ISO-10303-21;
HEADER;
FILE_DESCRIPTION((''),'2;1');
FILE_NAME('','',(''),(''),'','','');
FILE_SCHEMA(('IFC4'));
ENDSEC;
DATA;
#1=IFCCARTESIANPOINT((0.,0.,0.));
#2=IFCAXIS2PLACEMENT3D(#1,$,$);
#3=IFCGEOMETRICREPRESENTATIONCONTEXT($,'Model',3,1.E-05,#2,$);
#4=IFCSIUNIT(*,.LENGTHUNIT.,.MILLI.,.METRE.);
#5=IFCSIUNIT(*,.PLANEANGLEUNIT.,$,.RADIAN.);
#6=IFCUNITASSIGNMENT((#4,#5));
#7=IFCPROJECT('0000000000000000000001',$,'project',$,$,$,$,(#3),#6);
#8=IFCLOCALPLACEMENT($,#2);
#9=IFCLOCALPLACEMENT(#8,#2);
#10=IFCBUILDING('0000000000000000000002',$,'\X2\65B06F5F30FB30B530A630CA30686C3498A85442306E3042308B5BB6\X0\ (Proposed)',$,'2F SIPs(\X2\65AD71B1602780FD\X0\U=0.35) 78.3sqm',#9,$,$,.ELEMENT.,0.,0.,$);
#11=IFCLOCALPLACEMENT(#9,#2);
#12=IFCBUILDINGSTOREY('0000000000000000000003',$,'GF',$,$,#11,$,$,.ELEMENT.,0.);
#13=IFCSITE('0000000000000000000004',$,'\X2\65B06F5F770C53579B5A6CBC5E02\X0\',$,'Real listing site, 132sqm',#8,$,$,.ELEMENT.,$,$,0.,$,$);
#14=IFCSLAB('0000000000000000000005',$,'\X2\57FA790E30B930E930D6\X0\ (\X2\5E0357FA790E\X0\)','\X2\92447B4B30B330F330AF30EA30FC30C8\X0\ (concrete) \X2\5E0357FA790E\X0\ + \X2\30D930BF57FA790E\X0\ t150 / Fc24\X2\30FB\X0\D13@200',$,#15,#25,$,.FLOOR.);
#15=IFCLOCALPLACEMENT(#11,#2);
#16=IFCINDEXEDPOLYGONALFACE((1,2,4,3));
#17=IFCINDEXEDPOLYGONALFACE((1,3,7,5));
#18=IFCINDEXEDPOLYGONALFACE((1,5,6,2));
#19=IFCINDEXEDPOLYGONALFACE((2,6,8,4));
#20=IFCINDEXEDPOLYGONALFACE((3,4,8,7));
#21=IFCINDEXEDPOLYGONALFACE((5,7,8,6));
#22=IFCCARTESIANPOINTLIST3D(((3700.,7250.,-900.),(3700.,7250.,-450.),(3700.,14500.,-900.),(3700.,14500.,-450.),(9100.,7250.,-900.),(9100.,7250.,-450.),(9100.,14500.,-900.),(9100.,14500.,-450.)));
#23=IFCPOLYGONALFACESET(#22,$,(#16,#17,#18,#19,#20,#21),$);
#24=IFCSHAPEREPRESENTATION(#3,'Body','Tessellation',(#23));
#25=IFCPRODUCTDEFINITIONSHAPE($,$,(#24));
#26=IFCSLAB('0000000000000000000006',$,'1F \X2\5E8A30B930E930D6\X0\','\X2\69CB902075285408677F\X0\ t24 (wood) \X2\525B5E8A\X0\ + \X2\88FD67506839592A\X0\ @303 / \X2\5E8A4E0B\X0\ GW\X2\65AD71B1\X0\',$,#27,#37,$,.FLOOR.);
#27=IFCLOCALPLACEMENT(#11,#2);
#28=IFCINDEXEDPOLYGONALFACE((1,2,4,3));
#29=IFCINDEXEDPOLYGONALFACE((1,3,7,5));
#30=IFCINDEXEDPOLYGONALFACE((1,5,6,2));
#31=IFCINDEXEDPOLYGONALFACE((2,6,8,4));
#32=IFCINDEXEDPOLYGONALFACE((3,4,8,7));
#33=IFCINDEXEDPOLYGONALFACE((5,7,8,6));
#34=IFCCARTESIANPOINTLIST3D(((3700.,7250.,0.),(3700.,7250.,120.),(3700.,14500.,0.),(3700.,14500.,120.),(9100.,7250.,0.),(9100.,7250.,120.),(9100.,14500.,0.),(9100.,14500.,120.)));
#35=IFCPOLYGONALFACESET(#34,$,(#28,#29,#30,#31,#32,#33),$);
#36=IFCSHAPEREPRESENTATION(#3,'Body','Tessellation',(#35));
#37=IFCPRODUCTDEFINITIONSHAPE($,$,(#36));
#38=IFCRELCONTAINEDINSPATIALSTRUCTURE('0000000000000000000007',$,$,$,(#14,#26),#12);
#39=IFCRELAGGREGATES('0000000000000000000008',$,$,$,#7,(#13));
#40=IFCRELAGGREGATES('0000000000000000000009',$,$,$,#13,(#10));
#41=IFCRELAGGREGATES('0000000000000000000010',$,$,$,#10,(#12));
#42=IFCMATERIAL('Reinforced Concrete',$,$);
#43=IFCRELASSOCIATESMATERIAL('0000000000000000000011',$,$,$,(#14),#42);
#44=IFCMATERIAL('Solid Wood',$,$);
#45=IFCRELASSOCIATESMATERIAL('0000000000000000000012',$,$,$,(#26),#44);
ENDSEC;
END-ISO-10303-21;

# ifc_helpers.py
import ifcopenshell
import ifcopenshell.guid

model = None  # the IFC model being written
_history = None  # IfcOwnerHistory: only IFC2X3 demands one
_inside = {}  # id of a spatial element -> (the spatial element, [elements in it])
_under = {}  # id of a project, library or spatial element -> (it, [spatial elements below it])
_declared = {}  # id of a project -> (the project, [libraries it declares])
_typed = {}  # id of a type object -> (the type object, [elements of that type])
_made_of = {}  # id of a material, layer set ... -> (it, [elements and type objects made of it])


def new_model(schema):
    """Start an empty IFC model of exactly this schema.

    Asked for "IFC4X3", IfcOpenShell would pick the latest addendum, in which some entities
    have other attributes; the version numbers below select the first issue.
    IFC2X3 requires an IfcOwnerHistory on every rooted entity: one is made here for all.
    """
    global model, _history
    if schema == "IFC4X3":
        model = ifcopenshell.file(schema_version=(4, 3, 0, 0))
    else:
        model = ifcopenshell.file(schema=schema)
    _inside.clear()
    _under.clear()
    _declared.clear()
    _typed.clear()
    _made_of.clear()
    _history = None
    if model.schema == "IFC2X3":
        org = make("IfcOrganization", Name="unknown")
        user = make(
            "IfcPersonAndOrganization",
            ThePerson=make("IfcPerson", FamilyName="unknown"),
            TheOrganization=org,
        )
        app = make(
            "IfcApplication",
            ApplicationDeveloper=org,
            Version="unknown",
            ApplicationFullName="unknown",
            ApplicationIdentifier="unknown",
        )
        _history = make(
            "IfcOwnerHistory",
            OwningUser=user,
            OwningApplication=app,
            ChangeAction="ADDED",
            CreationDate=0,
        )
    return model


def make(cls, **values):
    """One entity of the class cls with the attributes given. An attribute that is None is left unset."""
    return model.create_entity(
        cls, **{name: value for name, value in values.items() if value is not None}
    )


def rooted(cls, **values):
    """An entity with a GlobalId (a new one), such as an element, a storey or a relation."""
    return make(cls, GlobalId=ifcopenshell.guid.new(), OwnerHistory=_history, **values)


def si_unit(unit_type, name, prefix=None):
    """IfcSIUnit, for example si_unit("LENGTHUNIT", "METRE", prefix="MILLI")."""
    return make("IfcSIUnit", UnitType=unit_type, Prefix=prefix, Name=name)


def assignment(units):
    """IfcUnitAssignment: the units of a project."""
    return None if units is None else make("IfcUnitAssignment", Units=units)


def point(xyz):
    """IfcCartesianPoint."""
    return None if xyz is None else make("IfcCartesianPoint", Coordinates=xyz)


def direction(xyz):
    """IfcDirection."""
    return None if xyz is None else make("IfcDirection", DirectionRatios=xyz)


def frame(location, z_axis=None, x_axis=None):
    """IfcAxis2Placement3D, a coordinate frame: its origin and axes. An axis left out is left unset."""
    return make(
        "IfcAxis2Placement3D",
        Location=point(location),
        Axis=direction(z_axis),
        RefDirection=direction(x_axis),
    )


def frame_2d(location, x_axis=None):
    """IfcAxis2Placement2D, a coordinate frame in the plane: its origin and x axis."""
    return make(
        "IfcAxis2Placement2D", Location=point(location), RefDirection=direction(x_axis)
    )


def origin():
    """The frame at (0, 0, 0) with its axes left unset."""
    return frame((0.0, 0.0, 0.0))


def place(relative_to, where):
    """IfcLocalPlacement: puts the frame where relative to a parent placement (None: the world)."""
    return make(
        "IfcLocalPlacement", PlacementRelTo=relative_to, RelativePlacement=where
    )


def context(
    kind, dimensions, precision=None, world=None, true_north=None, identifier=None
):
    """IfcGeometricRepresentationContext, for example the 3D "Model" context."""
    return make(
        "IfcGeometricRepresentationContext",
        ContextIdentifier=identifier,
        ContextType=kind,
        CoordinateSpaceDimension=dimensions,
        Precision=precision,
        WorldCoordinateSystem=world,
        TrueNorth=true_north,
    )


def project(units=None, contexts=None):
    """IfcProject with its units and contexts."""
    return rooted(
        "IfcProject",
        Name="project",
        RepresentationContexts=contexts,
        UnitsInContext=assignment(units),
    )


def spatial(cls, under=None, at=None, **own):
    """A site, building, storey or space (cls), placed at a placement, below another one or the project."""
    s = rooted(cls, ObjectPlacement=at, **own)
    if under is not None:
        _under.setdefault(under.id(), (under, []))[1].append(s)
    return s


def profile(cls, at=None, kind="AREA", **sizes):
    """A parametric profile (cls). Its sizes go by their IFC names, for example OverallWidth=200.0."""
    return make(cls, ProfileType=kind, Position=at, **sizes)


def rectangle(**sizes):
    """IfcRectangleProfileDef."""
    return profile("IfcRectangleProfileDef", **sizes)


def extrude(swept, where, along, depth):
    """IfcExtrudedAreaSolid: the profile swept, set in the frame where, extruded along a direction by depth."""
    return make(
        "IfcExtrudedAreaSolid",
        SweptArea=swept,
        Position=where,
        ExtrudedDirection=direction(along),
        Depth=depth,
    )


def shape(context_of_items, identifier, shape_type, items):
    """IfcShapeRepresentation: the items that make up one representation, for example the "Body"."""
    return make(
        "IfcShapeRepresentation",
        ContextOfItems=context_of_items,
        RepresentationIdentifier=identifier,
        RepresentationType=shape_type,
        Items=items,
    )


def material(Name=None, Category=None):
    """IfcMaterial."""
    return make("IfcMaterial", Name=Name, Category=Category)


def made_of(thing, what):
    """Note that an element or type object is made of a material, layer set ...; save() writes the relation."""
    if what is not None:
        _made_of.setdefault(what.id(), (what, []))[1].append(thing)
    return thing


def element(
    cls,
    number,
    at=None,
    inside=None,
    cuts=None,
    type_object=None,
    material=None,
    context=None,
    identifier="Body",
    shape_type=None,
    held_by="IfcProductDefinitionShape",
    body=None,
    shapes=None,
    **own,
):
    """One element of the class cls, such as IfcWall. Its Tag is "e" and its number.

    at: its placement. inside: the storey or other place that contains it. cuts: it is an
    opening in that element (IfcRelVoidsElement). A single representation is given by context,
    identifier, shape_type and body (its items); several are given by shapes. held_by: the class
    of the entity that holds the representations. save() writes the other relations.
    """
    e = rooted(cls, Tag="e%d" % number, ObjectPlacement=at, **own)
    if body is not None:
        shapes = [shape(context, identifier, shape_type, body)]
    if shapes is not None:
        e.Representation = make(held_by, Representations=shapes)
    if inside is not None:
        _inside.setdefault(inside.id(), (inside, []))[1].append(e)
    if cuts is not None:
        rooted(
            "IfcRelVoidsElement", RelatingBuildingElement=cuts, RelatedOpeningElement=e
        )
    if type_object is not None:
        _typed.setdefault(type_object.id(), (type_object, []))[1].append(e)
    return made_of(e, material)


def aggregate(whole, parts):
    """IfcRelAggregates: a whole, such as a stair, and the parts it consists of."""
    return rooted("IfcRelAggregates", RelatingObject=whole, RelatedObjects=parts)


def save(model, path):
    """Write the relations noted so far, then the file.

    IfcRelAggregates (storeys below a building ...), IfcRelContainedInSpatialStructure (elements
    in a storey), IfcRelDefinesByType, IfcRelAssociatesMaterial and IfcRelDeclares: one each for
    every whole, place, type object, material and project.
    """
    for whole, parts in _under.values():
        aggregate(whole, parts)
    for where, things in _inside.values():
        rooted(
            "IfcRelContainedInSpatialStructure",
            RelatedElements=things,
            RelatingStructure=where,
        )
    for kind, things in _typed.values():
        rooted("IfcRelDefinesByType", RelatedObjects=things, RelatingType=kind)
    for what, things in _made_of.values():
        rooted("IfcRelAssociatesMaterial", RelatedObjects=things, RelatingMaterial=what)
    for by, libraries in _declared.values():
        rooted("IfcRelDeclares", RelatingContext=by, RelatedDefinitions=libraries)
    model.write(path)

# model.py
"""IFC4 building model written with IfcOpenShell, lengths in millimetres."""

from ifc_helpers import new_model, si_unit, frame, frame_2d, origin, place, context, project, spatial, rectangle, extrude, material, element, save


model = new_model("IFC4")

# Units and contexts
model_context = context("Model", 3, precision=1e-05, world=origin())
ifc_project = project(units=[si_unit("LENGTHUNIT", "METRE", prefix="MILLI"), si_unit("PLANEANGLEUNIT", "RADIAN")], contexts=[model_context])

# Site, building, storey
site_placement = place(None, origin())
site = spatial("IfcSite", under=ifc_project, at=site_placement, Name="新潟県南魚沼市", ObjectType="Real listing site, 132sqm", CompositionType="ELEMENT", RefElevation=0.0)
building_placement = place(site_placement, origin())
building = spatial("IfcBuilding", under=site, at=building_placement, Name="新潟・サウナと水風呂のある家 (Proposed)", ObjectType="2F SIPs(断熱性能U=0.35) 78.3sqm", CompositionType="ELEMENT", ElevationOfRefHeight=0.0, ElevationOfTerrain=0.0)
storey_placement = place(building_placement, origin())
storey = spatial("IfcBuildingStorey", under=building, at=storey_placement, Name="GF", CompositionType="ELEMENT", Elevation=0.0)

# Shared definitions
ifc_material_1 = material(Name="Solid Wood")

# Slabs
ifc_material_2 = material(Name="Reinforced Concrete")
slab_1_placement = place(storey_placement, frame((1850.0, 3625.0, -450.0)))
element("IfcSlab", 1, at=slab_1_placement, inside=storey, material=ifc_material_2, Name="基礎スラブ (布基礎)", Description="鉄筋コンクリート (concrete) 布基礎 + ベタ基礎 t150 / Fc24・D13@200", PredefinedType="FLOOR", context=model_context, shape_type="SweptSolid", body=[
    extrude(rectangle(XDim=5400.0, YDim=7250.0, at=frame_2d((2700.0, 3625.0))), frame((1850.0, 3625.0, -450.0)), (0.0, 0.0, 1.0), 450.0),
])
slab_2_placement = place(storey_placement, frame((1850.0, 3625.0, 0.0)))
element("IfcSlab", 2, at=slab_2_placement, inside=storey, material=ifc_material_1, Name="1F 床スラブ", Description="構造用合板 t24 (wood) 剛床 + 製材根太 @303 / 床下 GW断熱", PredefinedType="FLOOR", context=model_context, shape_type="SweptSolid", body=[
    extrude(rectangle(XDim=5400.0, YDim=7250.0, at=frame_2d((2700.0, 3625.0))), frame((1850.0, 3625.0, 0.0)), (0.0, 0.0, 1.0), 120.0),
])

save(model, "model.ifc")
